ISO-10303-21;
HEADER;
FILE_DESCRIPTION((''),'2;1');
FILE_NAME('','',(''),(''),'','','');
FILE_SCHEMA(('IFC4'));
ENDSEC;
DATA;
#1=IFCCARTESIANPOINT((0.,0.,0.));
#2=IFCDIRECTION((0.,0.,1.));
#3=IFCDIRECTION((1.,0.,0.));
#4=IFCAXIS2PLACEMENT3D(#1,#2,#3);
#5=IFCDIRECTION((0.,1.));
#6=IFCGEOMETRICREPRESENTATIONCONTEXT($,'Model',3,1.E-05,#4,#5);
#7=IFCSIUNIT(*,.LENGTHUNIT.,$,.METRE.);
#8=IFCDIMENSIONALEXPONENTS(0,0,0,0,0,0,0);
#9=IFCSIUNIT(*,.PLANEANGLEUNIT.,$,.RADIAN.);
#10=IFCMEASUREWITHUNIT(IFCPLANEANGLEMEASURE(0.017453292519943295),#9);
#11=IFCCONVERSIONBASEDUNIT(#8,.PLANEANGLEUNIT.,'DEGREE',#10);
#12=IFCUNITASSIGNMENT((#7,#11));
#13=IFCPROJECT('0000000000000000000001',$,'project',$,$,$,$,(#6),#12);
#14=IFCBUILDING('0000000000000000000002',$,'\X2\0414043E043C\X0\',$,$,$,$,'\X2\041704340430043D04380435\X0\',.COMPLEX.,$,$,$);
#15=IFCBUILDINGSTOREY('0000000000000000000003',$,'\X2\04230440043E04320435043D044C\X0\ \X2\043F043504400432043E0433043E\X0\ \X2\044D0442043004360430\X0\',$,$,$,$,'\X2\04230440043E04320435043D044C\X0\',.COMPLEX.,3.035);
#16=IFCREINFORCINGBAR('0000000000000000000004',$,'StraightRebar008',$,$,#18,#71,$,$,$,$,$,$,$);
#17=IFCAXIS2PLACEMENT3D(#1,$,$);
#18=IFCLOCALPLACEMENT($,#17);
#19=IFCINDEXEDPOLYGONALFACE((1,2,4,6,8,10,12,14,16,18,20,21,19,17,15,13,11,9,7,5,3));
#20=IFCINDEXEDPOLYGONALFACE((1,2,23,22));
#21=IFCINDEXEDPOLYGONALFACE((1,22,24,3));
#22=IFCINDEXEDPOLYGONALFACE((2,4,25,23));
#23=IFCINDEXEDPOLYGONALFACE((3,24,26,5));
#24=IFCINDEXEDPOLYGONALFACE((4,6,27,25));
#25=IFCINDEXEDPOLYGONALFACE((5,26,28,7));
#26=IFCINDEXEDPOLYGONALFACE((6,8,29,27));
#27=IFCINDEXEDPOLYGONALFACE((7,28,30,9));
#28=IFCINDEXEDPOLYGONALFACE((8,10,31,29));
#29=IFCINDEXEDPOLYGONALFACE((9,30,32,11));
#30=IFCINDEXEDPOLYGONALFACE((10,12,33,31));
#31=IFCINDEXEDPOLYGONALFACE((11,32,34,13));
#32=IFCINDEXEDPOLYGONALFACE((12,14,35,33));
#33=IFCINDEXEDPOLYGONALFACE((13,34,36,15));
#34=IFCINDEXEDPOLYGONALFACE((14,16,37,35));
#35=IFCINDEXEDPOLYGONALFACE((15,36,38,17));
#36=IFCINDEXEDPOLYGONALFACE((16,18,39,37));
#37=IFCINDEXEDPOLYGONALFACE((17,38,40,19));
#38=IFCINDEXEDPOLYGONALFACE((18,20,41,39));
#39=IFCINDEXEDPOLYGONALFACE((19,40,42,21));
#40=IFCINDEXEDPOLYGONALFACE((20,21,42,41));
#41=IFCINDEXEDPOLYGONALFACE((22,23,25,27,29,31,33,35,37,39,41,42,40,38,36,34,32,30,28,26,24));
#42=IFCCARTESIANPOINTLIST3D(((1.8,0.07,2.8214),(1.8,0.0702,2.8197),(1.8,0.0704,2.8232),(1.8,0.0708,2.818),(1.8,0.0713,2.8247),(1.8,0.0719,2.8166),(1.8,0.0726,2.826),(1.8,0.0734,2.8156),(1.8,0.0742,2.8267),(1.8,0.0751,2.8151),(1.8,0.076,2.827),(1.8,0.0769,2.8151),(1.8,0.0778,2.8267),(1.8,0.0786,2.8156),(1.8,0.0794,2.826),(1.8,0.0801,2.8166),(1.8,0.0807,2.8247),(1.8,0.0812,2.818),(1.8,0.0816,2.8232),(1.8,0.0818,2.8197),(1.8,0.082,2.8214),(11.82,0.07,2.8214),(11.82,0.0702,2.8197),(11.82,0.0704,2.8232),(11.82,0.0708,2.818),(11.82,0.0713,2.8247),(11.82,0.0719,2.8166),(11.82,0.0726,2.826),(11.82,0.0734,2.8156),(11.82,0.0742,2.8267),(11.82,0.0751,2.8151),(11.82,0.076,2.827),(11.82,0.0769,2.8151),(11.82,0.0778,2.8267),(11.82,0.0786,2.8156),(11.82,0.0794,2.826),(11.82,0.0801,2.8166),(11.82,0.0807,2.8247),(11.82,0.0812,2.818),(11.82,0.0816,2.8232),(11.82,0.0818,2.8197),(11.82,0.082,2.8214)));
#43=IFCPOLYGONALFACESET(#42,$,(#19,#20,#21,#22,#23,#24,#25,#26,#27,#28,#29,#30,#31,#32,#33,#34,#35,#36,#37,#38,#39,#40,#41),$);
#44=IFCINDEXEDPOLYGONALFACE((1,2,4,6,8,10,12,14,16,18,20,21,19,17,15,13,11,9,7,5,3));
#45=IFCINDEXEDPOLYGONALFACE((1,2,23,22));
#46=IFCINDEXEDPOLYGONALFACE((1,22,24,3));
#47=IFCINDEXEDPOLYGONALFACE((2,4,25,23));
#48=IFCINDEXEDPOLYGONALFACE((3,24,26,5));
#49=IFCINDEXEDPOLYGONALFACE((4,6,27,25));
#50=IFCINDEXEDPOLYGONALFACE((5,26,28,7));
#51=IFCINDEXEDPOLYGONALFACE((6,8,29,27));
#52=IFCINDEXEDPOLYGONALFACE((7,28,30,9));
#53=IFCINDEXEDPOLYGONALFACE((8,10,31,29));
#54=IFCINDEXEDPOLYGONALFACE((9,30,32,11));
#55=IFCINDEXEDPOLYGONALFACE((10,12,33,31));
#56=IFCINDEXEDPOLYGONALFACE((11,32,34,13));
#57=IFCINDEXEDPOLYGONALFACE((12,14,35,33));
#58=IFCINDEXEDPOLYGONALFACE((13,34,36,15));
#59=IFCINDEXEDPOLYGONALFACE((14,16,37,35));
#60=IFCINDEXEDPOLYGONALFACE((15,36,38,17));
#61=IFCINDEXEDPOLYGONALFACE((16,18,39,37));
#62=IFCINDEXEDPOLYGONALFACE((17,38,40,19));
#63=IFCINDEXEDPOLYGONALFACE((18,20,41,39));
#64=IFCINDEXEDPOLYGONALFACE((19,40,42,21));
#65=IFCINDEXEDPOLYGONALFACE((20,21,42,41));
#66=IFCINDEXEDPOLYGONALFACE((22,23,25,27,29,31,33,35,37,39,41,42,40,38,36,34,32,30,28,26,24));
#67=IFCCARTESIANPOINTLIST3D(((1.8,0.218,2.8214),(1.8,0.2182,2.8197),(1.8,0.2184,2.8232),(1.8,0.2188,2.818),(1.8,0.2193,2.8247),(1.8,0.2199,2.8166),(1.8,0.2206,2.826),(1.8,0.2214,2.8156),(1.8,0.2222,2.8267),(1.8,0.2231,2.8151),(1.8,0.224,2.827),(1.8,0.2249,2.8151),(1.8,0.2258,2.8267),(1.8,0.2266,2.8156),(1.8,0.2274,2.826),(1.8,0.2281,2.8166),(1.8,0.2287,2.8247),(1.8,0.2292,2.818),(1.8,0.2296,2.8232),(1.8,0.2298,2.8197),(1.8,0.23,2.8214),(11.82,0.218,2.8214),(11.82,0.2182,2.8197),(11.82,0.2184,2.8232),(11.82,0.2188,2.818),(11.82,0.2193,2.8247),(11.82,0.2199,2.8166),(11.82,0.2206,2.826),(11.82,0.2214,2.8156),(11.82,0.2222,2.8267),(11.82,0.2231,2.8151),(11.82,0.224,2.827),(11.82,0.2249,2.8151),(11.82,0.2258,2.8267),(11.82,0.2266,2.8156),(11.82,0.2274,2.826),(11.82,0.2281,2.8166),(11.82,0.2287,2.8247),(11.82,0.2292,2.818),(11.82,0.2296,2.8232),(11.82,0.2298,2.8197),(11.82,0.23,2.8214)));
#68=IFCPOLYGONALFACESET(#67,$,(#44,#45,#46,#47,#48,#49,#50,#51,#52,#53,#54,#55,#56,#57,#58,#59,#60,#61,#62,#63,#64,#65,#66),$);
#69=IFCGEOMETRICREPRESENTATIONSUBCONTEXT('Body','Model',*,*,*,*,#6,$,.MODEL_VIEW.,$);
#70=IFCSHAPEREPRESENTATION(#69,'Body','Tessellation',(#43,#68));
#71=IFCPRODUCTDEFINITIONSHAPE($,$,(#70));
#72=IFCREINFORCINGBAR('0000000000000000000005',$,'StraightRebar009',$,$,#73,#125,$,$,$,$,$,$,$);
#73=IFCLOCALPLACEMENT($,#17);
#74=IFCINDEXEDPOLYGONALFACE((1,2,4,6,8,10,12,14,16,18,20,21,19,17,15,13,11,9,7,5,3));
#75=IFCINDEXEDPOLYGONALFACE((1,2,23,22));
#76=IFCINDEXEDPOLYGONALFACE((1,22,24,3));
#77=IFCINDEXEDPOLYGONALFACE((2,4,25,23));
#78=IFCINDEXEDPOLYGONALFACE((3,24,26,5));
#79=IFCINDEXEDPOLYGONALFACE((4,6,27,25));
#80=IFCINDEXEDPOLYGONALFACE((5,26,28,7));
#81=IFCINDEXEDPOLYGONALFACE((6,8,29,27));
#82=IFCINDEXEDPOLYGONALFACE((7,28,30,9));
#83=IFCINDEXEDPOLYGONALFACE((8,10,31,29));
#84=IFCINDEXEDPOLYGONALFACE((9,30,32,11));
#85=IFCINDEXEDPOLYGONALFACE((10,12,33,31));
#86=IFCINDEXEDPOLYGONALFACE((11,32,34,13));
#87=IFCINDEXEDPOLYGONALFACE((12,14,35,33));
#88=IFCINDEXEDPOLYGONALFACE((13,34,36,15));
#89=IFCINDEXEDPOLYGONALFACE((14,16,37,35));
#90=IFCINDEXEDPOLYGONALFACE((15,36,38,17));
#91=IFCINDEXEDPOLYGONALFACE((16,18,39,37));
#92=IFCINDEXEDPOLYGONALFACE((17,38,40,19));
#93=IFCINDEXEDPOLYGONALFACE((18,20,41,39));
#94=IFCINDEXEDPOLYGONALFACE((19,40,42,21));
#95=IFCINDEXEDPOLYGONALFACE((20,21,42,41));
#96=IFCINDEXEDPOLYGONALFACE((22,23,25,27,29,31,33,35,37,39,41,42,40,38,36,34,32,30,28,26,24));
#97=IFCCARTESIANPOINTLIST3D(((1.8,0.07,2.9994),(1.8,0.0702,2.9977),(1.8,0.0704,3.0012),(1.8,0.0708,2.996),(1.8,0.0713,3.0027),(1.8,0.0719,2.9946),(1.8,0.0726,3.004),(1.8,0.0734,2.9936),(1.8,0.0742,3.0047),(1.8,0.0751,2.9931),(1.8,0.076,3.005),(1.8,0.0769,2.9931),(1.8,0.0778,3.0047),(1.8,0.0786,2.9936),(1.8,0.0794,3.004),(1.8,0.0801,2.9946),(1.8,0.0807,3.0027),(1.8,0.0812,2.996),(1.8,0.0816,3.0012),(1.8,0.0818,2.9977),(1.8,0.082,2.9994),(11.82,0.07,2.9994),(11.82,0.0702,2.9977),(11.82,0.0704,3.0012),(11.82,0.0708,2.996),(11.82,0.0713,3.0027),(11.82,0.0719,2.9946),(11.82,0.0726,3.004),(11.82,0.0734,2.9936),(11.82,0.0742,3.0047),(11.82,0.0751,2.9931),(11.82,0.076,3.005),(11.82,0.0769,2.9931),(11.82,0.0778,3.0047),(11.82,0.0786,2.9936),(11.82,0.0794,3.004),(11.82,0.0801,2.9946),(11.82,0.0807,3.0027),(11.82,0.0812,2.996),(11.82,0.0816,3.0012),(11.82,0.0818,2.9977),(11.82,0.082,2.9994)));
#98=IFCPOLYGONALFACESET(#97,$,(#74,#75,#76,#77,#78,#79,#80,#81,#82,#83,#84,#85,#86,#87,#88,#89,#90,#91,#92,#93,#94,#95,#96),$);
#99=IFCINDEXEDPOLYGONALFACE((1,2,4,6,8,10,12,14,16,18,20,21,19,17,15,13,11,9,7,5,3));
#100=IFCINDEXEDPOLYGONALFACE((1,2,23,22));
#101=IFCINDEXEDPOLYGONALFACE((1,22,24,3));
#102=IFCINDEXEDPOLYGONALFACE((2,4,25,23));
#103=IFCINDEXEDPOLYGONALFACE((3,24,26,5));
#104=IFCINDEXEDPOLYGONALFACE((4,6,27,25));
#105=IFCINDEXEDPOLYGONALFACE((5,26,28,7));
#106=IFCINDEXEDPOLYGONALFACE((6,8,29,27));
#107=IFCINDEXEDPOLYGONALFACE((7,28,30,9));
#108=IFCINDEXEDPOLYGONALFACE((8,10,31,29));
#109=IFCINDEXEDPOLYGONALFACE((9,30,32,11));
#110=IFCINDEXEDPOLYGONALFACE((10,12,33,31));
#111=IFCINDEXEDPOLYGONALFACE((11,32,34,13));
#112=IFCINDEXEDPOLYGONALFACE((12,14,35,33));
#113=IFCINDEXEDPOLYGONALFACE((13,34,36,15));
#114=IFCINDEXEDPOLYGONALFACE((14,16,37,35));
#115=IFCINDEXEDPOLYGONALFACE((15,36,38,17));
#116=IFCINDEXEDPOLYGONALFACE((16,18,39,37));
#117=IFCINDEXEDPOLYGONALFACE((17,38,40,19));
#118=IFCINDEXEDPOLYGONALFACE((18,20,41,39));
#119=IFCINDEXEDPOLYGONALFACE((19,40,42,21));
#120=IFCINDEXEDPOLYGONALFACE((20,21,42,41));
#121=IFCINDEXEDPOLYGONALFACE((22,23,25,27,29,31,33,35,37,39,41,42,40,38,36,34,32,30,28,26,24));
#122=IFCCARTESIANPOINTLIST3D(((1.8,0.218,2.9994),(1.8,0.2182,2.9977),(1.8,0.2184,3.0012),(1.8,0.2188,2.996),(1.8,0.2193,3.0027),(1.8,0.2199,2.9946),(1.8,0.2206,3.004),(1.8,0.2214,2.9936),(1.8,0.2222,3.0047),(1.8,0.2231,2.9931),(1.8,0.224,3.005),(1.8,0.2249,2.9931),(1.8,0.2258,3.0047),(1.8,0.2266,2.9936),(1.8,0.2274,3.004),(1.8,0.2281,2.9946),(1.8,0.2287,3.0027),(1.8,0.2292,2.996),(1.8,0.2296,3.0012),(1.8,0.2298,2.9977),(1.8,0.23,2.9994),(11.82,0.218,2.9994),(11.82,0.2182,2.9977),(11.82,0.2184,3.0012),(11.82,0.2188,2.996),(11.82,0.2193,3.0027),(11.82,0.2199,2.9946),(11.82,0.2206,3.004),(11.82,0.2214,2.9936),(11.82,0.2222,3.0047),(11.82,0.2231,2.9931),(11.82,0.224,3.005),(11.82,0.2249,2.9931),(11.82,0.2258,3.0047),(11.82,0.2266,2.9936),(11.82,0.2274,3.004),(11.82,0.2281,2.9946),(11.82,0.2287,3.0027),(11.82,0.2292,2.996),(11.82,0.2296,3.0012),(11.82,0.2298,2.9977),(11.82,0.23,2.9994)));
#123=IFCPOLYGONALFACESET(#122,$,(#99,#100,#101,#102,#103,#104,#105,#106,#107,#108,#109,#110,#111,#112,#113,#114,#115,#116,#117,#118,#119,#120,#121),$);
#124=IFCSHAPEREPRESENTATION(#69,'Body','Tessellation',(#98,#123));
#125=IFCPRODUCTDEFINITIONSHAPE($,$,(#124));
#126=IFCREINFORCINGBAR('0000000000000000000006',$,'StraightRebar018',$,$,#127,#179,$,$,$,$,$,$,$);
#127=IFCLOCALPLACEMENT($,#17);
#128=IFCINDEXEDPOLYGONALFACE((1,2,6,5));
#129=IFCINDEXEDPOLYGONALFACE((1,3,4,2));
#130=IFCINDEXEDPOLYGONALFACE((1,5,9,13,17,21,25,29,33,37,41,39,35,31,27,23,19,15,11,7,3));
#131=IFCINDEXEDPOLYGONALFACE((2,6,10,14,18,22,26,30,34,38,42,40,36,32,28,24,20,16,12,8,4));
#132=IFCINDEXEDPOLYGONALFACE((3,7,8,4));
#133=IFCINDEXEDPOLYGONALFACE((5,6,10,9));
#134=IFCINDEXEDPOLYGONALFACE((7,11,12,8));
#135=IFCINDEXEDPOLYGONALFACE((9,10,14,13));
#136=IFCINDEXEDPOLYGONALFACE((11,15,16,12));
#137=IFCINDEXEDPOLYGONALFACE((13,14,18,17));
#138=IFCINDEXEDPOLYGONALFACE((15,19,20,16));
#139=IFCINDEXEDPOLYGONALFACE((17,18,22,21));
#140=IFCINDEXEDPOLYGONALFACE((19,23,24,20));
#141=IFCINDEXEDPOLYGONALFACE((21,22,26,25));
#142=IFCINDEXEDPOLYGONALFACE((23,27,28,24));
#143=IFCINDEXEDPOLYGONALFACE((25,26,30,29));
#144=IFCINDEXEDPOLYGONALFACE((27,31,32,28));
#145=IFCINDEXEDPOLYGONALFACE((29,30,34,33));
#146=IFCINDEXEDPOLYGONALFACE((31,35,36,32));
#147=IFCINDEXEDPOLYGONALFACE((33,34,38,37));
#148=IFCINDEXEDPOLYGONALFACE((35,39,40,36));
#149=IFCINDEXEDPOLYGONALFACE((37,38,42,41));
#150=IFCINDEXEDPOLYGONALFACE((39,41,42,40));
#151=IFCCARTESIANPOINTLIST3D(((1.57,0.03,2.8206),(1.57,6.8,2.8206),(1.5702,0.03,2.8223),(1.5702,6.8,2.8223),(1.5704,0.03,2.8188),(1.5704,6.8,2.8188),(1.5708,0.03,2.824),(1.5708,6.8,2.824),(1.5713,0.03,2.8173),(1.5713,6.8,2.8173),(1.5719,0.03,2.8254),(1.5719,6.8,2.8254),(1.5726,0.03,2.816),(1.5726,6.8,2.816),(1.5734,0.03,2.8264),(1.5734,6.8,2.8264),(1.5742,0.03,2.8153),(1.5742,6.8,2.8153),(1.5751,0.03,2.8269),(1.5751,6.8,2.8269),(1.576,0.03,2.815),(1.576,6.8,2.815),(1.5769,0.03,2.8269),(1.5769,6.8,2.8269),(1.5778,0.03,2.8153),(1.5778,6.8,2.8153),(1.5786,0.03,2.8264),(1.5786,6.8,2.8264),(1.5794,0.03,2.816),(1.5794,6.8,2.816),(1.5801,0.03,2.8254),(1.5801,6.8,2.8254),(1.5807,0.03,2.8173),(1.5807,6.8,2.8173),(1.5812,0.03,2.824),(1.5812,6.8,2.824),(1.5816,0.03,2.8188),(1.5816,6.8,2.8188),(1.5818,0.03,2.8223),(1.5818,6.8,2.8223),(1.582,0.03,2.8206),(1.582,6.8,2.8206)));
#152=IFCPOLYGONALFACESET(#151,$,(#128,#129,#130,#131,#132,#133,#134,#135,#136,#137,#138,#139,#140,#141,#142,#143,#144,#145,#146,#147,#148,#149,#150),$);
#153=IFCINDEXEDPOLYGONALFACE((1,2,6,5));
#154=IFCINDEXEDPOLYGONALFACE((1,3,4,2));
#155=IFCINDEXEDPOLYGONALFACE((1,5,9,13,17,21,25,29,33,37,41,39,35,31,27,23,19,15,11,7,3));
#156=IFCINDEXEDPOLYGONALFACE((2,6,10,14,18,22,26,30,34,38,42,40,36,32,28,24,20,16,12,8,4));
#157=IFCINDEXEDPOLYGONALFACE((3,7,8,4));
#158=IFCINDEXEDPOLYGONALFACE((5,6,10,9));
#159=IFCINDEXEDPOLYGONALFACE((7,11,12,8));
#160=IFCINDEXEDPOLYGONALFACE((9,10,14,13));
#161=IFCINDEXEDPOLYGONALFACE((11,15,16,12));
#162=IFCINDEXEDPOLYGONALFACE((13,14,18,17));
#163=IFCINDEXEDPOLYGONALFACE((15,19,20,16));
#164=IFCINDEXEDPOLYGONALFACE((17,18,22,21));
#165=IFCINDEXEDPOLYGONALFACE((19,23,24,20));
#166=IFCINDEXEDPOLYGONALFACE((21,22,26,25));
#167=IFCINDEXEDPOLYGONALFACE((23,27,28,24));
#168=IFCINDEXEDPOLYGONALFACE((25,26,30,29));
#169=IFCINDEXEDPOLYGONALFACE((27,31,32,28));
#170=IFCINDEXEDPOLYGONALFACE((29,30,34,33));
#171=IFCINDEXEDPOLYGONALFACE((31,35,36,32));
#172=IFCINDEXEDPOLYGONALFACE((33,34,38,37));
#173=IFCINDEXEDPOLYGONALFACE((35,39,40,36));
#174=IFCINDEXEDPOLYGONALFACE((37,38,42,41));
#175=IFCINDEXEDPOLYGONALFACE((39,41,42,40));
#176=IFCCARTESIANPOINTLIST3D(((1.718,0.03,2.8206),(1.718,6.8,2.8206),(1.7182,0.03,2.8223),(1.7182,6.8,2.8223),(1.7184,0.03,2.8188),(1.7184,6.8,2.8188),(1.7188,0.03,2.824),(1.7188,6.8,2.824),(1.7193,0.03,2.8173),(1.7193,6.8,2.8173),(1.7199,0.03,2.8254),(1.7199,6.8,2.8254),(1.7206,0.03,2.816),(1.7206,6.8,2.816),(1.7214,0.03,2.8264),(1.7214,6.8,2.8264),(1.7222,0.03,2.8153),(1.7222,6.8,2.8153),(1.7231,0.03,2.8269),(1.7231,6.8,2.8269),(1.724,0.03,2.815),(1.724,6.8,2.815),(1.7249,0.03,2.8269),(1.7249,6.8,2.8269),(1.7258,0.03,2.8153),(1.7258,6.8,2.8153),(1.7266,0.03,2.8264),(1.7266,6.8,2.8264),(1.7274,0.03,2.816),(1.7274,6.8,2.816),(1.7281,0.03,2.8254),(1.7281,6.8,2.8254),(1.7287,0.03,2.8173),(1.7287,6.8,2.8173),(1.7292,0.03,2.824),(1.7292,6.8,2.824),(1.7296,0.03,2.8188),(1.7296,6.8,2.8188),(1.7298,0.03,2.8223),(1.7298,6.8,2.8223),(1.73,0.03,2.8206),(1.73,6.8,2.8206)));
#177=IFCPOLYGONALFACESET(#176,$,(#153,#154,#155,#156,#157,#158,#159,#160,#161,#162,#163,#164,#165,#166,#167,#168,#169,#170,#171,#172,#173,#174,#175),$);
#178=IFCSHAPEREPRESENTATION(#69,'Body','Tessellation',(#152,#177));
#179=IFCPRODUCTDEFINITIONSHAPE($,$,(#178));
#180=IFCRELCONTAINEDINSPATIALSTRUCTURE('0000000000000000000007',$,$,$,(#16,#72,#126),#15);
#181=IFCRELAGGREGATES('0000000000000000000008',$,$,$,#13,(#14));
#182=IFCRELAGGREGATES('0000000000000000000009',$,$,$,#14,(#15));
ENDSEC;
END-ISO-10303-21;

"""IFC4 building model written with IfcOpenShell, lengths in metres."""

from ifc_helpers import new_model, entity, si_unit, converted_unit, direction, origin_with_axes, place, context, subcontext, project, spatial, element, save


model = new_model("IFC4")

# Units and contexts
model_context = context("Model", 3, precision=1e-05, world=origin_with_axes(), true_north=direction((0.0, 1.0)))
body_context = subcontext(model_context, "Body", "Model", "MODEL_VIEW")
ifc_project = project(units=[si_unit("LENGTHUNIT", "METRE"), converted_unit("PLANEANGLEUNIT", "DEGREE", entity("IfcPlaneAngleMeasure", 0.017453292519943295), si_unit("PLANEANGLEUNIT", "RADIAN"), dimensions=[0, 0, 0, 0, 0, 0, 0])], contexts=[model_context])

# Building, storey
building = spatial("IfcBuilding", under=ifc_project, Name="Дом", LongName="Здание", CompositionType="COMPLEX")
storey = spatial("IfcBuildingStorey", under=building, Name="Уровень первого этажа", LongName="Уровень", CompositionType="COMPLEX", Elevation=3.035)

# Shared definitions
placement = place(None, origin_with_axes())

# Reinforcing bars
element("IfcReinforcingBar", 1, at=placement, inside=storey, Name="StraightRebar008", context=body_context, shape_type="SweptSolid", body=[
    entity("IfcSweptDiskSolid", entity("IfcCompositeCurve", [entity("IfcCompositeCurveSegment", "CONTINUOUS", True, entity("IfcPolyline", [entity("IfcCartesianPoint", [1.8, 0.076, 2.821]), entity("IfcCartesianPoint", [11.82, 0.076, 2.821])]))], False), 0.006),
    entity("IfcSweptDiskSolid", entity("IfcCompositeCurve", [entity("IfcCompositeCurveSegment", "CONTINUOUS", True, entity("IfcPolyline", [entity("IfcCartesianPoint", [1.8, 0.224, 2.821]), entity("IfcCartesianPoint", [11.82, 0.224, 2.821])]))], False), 0.006),
])
element("IfcReinforcingBar", 2, at=placement, inside=storey, Name="StraightRebar009", context=body_context, shape_type="SweptSolid", body=[
    entity("IfcSweptDiskSolid", entity("IfcCompositeCurve", [entity("IfcCompositeCurveSegment", "CONTINUOUS", True, entity("IfcPolyline", [entity("IfcCartesianPoint", [1.8, 0.076, 2.999]), entity("IfcCartesianPoint", [11.82, 0.076, 2.999])]))], False), 0.006),
    entity("IfcSweptDiskSolid", entity("IfcCompositeCurve", [entity("IfcCompositeCurveSegment", "CONTINUOUS", True, entity("IfcPolyline", [entity("IfcCartesianPoint", [1.8, 0.224, 2.999]), entity("IfcCartesianPoint", [11.82, 0.224, 2.999])]))], False), 0.006),
])
element("IfcReinforcingBar", 3, at=placement, inside=storey, Name="StraightRebar018", context=body_context, shape_type="SweptSolid", body=[
    entity("IfcSweptDiskSolid", entity("IfcCompositeCurve", [entity("IfcCompositeCurveSegment", "CONTINUOUS", True, entity("IfcPolyline", [entity("IfcCartesianPoint", [1.576, 6.8, 2.821]), entity("IfcCartesianPoint", [1.576, 0.03, 2.821])]))], False), 0.006),
    entity("IfcSweptDiskSolid", entity("IfcCompositeCurve", [entity("IfcCompositeCurveSegment", "CONTINUOUS", True, entity("IfcPolyline", [entity("IfcCartesianPoint", [1.724, 6.8, 2.821]), entity("IfcCartesianPoint", [1.724, 0.03, 2.821])]))], False), 0.006),
])

save(model, "model.ifc")
